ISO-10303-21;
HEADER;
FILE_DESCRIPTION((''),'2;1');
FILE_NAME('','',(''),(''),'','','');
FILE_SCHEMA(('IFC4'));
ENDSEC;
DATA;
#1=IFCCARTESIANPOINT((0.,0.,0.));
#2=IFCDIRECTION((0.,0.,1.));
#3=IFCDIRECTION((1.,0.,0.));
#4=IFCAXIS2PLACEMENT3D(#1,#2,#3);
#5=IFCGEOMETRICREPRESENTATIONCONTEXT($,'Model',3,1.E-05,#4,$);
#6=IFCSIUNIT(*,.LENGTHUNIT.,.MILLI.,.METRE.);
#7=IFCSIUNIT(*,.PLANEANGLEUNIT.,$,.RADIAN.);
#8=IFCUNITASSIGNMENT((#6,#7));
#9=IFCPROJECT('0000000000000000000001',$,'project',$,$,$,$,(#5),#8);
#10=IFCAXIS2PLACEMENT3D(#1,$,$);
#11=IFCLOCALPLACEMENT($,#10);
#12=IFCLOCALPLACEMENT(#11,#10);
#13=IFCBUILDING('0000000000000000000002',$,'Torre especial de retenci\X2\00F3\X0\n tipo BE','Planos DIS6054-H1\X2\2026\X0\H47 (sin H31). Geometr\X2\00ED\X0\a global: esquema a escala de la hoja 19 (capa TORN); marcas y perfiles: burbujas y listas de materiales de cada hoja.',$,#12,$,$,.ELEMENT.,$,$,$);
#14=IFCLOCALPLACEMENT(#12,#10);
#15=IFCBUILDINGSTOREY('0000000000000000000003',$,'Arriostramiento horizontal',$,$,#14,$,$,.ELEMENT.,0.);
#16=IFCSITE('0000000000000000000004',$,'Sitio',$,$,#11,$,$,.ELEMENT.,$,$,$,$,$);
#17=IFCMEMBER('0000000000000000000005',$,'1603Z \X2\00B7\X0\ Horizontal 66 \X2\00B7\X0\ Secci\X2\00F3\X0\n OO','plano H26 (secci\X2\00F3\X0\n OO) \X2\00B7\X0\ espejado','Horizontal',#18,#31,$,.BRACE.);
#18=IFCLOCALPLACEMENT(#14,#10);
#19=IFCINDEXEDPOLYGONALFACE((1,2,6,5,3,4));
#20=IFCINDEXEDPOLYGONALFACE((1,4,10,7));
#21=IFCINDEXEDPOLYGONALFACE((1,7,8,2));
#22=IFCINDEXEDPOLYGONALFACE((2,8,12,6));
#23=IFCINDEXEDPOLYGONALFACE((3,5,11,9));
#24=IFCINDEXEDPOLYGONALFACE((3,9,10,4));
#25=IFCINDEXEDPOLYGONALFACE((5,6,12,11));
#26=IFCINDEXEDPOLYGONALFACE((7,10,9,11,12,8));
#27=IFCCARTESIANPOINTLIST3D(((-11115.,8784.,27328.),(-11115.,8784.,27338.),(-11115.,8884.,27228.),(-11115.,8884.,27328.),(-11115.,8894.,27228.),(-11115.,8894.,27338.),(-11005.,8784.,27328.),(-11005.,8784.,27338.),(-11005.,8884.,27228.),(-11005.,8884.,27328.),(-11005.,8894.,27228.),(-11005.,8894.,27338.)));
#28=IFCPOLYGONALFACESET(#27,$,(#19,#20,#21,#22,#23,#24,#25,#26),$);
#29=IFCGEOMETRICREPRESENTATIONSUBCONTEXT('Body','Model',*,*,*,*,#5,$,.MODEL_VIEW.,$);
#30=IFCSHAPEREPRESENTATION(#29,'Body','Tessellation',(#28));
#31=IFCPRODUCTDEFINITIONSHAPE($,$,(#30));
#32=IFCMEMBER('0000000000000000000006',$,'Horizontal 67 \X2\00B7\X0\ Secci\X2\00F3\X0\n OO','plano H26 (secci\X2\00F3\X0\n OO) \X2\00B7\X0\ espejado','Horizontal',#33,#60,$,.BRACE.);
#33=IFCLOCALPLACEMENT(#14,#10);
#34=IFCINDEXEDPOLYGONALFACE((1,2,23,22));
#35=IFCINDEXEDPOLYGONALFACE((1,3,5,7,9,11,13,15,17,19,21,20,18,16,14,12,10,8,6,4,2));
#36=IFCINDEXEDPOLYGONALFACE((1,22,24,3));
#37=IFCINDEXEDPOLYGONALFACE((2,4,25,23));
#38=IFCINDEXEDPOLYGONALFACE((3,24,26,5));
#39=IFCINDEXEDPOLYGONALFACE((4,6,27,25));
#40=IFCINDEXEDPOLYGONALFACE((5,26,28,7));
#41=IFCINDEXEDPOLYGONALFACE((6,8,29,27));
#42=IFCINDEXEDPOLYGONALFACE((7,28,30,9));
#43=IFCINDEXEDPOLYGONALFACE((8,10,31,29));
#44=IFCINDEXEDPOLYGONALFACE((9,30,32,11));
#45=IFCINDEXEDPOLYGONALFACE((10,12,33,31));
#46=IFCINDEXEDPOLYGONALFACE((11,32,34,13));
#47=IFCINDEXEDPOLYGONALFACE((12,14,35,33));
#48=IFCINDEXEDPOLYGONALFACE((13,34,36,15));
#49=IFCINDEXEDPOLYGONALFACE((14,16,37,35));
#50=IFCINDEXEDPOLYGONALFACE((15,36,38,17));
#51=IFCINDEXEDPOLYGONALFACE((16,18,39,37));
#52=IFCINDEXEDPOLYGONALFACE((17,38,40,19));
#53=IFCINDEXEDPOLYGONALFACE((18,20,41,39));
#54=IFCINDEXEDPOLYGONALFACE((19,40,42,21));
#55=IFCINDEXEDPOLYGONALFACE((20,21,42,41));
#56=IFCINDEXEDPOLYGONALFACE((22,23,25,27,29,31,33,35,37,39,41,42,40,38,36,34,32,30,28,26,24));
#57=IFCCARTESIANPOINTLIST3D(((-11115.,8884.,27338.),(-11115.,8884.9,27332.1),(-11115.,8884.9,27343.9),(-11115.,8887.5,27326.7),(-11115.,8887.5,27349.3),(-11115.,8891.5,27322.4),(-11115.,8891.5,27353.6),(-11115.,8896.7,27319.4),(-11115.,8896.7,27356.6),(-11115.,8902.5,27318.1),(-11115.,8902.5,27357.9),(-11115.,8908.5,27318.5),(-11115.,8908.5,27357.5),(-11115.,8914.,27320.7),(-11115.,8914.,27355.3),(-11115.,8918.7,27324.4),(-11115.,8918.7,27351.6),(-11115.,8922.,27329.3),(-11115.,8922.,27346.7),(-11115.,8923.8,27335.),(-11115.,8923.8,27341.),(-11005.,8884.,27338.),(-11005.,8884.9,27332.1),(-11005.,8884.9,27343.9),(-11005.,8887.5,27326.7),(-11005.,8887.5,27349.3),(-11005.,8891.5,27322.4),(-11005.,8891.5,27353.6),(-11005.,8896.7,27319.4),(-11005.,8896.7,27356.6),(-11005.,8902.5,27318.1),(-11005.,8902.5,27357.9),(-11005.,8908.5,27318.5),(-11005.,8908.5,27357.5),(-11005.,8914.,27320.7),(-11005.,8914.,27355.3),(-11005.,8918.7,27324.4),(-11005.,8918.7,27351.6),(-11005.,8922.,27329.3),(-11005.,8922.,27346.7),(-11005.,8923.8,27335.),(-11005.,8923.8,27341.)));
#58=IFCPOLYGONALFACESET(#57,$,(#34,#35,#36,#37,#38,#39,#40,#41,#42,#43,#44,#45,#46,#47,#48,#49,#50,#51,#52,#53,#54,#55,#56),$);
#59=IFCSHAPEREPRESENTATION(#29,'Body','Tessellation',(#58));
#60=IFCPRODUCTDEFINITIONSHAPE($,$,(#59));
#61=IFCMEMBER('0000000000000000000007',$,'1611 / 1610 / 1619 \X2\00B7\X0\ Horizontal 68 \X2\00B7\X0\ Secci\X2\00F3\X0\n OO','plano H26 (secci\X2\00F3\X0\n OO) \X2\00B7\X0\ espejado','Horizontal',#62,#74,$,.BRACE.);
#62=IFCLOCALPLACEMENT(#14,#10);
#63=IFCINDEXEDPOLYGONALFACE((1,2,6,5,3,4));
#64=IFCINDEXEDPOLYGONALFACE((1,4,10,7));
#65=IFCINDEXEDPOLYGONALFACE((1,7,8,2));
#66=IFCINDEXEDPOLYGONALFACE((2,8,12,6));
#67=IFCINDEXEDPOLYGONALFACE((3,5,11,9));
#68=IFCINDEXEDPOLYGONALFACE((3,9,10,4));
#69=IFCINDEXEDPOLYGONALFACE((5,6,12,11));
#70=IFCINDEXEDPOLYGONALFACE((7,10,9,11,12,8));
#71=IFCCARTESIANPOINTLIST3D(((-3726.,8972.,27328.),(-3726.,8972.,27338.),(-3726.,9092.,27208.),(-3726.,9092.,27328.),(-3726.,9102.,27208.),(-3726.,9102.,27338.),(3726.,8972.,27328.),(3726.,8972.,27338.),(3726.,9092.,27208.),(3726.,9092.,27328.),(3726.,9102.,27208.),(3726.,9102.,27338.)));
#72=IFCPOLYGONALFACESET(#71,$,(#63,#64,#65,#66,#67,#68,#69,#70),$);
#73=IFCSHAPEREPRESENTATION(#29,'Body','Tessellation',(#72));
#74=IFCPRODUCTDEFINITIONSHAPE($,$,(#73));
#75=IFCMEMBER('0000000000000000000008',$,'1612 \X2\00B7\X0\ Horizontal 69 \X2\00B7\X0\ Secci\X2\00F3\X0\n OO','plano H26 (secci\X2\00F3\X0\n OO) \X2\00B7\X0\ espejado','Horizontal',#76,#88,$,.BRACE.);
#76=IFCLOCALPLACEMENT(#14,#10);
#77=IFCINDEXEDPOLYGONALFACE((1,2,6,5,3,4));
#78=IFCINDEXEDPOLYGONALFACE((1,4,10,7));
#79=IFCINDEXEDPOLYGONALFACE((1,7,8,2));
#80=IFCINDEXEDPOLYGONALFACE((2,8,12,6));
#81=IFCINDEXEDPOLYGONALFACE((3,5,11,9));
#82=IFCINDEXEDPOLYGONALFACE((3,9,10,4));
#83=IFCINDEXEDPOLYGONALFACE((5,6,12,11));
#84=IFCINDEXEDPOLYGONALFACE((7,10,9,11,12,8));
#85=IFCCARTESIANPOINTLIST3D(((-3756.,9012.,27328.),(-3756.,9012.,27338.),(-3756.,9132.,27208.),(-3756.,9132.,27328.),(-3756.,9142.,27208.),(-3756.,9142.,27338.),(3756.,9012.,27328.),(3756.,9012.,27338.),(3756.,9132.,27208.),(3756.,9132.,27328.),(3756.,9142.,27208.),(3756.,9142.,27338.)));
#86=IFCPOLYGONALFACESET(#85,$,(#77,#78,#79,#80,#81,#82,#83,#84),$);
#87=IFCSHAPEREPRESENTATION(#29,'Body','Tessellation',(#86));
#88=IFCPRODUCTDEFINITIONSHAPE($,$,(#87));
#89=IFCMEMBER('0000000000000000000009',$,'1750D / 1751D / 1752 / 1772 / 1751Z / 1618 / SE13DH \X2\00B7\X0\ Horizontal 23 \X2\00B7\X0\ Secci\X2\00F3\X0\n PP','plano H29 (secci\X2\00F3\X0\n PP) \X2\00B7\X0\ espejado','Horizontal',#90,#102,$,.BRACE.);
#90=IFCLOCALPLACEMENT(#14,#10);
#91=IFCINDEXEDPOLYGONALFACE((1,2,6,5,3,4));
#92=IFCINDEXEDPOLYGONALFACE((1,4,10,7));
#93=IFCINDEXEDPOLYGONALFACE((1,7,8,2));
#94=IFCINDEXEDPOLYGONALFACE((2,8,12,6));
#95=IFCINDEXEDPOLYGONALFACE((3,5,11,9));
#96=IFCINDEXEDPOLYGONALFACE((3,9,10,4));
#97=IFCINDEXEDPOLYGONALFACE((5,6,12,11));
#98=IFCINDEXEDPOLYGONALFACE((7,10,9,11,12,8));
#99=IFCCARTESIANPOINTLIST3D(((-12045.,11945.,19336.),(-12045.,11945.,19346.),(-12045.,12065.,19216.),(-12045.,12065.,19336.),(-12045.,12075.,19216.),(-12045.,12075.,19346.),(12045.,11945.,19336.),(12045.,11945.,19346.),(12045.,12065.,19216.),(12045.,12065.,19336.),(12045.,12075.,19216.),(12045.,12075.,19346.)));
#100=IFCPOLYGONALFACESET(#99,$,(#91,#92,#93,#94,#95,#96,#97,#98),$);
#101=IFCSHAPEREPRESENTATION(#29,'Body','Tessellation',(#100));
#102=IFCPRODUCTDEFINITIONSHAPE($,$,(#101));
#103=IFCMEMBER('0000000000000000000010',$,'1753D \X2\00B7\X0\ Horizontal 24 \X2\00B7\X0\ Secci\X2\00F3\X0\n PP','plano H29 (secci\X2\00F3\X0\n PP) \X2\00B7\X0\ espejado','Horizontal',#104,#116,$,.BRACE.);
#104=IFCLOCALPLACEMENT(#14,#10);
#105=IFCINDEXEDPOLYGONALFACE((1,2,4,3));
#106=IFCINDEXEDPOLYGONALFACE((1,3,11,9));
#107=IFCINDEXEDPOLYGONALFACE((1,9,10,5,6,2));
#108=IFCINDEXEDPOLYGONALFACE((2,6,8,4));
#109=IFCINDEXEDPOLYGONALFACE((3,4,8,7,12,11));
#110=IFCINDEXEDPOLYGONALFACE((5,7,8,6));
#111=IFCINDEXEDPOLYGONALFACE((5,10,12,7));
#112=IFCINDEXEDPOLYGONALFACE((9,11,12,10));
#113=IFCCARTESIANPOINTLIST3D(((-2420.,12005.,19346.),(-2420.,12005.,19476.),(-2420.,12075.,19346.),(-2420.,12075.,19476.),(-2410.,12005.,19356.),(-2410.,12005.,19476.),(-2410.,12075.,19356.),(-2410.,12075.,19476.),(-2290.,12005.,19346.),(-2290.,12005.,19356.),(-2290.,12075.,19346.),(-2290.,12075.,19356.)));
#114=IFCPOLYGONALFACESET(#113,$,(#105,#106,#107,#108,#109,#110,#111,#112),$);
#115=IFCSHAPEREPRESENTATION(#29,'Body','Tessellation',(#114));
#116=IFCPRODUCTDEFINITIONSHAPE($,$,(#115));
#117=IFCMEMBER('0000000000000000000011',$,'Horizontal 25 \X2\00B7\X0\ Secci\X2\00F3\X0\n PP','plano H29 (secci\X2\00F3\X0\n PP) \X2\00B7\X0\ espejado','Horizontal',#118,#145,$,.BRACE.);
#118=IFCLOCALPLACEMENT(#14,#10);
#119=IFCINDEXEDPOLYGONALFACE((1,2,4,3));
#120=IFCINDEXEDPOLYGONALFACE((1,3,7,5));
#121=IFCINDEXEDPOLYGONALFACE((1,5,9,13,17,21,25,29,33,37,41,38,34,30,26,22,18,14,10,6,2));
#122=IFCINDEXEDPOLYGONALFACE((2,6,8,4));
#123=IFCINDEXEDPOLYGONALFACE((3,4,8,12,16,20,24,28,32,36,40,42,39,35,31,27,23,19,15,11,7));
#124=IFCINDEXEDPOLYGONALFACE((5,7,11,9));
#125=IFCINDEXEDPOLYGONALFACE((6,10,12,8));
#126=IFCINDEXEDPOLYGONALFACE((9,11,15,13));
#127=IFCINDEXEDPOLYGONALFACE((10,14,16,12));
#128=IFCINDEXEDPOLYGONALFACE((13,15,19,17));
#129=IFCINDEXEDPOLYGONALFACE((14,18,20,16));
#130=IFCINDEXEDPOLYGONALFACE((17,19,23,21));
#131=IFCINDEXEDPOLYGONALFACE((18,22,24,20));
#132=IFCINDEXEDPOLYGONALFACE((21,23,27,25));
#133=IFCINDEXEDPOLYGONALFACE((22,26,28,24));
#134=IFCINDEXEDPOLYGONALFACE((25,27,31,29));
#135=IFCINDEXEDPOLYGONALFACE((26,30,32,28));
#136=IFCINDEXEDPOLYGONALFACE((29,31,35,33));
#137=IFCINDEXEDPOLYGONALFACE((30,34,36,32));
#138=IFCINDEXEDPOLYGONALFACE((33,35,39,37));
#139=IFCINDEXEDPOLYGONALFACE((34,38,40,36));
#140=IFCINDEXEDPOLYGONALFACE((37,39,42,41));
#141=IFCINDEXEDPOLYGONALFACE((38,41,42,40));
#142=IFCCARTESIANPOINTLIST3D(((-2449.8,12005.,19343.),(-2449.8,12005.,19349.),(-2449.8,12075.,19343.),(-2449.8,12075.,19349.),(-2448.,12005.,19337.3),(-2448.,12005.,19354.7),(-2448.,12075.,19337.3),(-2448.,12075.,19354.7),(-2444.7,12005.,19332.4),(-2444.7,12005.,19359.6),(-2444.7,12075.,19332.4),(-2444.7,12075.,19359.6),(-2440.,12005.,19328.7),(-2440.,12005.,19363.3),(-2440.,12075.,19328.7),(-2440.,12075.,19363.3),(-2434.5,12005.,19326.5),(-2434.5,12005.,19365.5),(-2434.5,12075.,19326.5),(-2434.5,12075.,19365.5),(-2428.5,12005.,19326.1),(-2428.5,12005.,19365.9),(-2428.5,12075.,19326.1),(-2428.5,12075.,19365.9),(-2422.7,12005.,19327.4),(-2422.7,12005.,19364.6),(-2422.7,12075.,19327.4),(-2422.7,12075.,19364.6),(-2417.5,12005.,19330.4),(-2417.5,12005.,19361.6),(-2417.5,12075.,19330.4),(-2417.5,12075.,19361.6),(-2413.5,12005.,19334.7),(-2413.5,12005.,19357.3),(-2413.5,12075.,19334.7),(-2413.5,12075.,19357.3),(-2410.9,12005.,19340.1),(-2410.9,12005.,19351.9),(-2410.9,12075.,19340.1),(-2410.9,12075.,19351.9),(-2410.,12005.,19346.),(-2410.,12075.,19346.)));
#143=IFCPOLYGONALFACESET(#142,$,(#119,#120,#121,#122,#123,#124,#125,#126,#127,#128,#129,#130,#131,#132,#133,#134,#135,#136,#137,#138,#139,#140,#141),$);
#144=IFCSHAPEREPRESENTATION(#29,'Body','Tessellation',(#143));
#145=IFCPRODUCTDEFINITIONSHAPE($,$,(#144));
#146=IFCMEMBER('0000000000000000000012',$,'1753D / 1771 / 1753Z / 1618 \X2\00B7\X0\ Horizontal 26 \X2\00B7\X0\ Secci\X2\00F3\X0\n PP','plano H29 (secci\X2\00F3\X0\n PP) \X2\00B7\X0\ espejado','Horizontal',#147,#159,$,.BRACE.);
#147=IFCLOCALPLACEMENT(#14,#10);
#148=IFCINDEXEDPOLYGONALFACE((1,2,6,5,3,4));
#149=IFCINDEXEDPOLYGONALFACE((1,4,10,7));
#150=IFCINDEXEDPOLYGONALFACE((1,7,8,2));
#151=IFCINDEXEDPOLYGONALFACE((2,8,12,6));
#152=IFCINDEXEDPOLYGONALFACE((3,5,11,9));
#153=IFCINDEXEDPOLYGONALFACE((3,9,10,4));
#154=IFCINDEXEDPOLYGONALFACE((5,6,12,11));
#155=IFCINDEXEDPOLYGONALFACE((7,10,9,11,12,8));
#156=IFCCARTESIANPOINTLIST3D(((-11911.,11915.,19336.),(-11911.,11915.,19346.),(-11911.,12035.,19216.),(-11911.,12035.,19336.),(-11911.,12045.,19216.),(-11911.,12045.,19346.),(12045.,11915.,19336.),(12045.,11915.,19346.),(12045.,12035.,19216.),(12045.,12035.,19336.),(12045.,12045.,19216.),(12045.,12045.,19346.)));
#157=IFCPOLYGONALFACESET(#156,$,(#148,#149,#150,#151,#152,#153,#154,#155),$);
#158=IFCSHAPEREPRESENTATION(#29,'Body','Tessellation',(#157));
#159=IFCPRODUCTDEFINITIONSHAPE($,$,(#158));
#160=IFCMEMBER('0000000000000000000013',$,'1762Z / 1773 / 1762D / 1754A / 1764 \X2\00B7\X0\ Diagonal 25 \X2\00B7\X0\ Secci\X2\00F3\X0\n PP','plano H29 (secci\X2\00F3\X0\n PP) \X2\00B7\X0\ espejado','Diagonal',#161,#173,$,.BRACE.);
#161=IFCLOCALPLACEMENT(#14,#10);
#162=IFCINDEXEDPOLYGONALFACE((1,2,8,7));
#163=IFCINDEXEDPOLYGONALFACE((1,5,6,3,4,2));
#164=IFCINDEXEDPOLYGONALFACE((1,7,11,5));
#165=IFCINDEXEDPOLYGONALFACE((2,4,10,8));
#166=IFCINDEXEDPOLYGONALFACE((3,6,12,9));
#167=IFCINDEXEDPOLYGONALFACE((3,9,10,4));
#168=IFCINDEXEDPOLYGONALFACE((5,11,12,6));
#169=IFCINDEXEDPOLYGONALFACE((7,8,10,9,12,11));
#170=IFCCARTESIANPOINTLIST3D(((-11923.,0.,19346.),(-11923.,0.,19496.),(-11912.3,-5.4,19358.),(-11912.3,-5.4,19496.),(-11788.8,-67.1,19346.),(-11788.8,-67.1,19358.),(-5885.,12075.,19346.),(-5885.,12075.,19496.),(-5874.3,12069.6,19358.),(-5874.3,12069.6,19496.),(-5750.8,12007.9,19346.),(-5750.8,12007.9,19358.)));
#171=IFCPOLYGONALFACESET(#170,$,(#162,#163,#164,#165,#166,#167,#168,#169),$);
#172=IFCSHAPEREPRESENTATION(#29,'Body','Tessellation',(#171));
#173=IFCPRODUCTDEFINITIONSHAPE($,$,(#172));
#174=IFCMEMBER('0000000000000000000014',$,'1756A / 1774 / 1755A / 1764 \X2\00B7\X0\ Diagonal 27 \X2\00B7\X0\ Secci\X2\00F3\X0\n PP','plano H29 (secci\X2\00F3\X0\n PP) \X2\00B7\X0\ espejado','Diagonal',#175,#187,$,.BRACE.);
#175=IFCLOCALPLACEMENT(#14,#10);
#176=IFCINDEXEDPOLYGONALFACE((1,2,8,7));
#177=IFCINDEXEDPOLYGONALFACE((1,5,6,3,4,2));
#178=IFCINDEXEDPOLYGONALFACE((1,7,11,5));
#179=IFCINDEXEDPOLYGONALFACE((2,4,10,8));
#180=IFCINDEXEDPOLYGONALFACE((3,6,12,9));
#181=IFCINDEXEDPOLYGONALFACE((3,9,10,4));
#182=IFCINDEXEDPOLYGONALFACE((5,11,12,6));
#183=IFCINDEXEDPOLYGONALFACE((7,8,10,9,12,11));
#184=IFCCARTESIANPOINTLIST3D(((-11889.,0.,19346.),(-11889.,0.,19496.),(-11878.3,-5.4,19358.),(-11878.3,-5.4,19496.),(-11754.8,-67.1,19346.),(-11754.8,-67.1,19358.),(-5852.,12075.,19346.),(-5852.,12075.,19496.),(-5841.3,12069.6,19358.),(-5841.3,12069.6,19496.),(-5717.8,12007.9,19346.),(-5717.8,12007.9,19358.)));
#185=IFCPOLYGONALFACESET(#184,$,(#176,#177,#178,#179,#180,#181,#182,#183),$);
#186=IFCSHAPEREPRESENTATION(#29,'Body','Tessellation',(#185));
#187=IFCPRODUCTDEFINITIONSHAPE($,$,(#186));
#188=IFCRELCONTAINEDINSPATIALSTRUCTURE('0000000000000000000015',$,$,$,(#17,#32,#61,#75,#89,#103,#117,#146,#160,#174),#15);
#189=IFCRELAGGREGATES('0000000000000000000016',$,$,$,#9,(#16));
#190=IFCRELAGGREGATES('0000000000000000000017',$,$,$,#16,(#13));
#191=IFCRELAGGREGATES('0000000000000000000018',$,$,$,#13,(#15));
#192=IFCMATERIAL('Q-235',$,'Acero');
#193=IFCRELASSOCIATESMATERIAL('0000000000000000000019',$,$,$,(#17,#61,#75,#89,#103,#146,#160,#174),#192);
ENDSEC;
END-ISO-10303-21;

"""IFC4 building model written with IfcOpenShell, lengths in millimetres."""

from ifc_helpers import new_model, si_unit, frame, frame_2d, origin, origin_with_axes, place, context, subcontext, project, spatial, circle, l_section, extrude, material, element, save


model = new_model("IFC4")

# Units and contexts
model_context = context("Model", 3, precision=1e-05, world=origin_with_axes())
body_context = subcontext(model_context, "Body", "Model", "MODEL_VIEW")
ifc_project = project(units=[si_unit("LENGTHUNIT", "METRE", prefix="MILLI"), si_unit("PLANEANGLEUNIT", "RADIAN")], contexts=[model_context])

# Site, building, storey
site_placement = place(None, origin())
site = spatial("IfcSite", under=ifc_project, at=site_placement, Name="Sitio", CompositionType="ELEMENT")
building_placement = place(site_placement, origin())
building = spatial("IfcBuilding", under=site, at=building_placement, Name="Torre especial de retención tipo BE", Description="Planos DIS6054-H1…H47 (sin H31). Geometría global: esquema a escala de la hoja 19 (capa TORN); marcas y perfiles: burbujas y listas de materiales de cada hoja.", CompositionType="ELEMENT")
storey_placement = place(building_placement, origin())
storey = spatial("IfcBuildingStorey", under=building, at=storey_placement, Name="Arriostramiento horizontal", CompositionType="ELEMENT", Elevation=0.0)

# Members
ifc_material = material(Name="Q-235", Category="Acero")
member_1_placement = place(storey_placement, frame((-11115.0, 8894.0, 27338.0), z_axis=(1.0, 0.0, 0.0), x_axis=(0.0, -1.0, 0.0)))
element("IfcMember", 1, at=member_1_placement, inside=storey, material=ifc_material, Name="1603Z · Horizontal 66 · Sección OO", Description="plano H26 (sección OO) · espejado", ObjectType="Horizontal", PredefinedType="BRACE", context=body_context, shape_type="SweptSolid", body=[
    extrude(l_section(Depth=110.0, Width=110.0, Thickness=10.0, at=frame_2d((55.0, 55.0))), None, (0.0, 0.0, 1.0), 110.0),
])
member_2_placement = place(storey_placement, frame((-11115.0, 8904.0, 27338.0), z_axis=(1.0, 0.0, 0.0), x_axis=(0.0, -1.0, 0.0)))
element("IfcMember", 2, at=member_2_placement, inside=storey, Name="Horizontal 67 · Sección OO", Description="plano H26 (sección OO) · espejado", ObjectType="Horizontal", PredefinedType="BRACE", context=body_context, shape_type="SweptSolid", body=[
    extrude(circle(Radius=20.0), None, (0.0, 0.0, 1.0), 110.0),
])
member_3_placement = place(storey_placement, frame((-3726.0, 9102.0, 27338.0), z_axis=(1.0, 0.0, 0.0), x_axis=(0.0, -1.0, 0.0)))
element("IfcMember", 3, at=member_3_placement, inside=storey, material=ifc_material, Name="1611 / 1610 / 1619 · Horizontal 68 · Sección OO", Description="plano H26 (sección OO) · espejado", ObjectType="Horizontal", PredefinedType="BRACE", context=body_context, shape_type="SweptSolid", body=[
    extrude(l_section(Depth=130.0, Width=130.0, Thickness=10.0, at=frame_2d((65.0, 65.0))), None, (0.0, 0.0, 1.0), 7452.0),
])
member_4_placement = place(storey_placement, frame((-3756.0, 9142.0, 27338.0), z_axis=(1.0, 0.0, 0.0), x_axis=(0.0, -1.0, 0.0)))
element("IfcMember", 4, at=member_4_placement, inside=storey, material=ifc_material, Name="1612 · Horizontal 69 · Sección OO", Description="plano H26 (sección OO) · espejado", ObjectType="Horizontal", PredefinedType="BRACE", context=body_context, shape_type="SweptSolid", body=[
    extrude(l_section(Depth=130.0, Width=130.0, Thickness=10.0, at=frame_2d((65.0, 65.0))), None, (0.0, 0.0, 1.0), 7512.0),
])
member_5_placement = place(storey_placement, frame((-12045.0, 12075.0, 19346.0), z_axis=(1.0, 0.0, 0.0), x_axis=(0.0, -1.0, 0.0)))
element("IfcMember", 5, at=member_5_placement, inside=storey, material=ifc_material, Name="1750D / 1751D / 1752 / 1772 / 1751Z / 1618 / SE13DH · Horizontal 23 · Sección PP", Description="plano H29 (sección PP) · espejado", ObjectType="Horizontal", PredefinedType="BRACE", context=body_context, shape_type="SweptSolid", body=[
    extrude(l_section(Depth=130.0, Width=130.0, Thickness=10.0, at=frame_2d((65.0, 65.0))), None, (0.0, 0.0, 1.0), 24090.0),
])
member_6_placement = place(storey_placement, frame((-2420.0, 12075.0, 19346.0), z_axis=(0.0, -1.0, 0.0), x_axis=(1.0, 0.0, 0.0)))
element("IfcMember", 6, at=member_6_placement, inside=storey, material=ifc_material, Name="1753D · Horizontal 24 · Sección PP", Description="plano H29 (sección PP) · espejado", ObjectType="Horizontal", PredefinedType="BRACE", context=body_context, shape_type="SweptSolid", body=[
    extrude(l_section(Depth=130.0, Width=130.0, Thickness=10.0, at=frame_2d((65.0, 65.0))), None, (0.0, 0.0, 1.0), 70.0),
])
member_7_placement = place(storey_placement, frame((-2430.0, 12075.0, 19346.0), z_axis=(0.0, -1.0, 0.0), x_axis=(1.0, 0.0, 0.0)))
element("IfcMember", 7, at=member_7_placement, inside=storey, Name="Horizontal 25 · Sección PP", Description="plano H29 (sección PP) · espejado", ObjectType="Horizontal", PredefinedType="BRACE", context=body_context, shape_type="SweptSolid", body=[
    extrude(circle(Radius=20.0), None, (0.0, 0.0, 1.0), 70.0),
])
member_8_placement = place(storey_placement, frame((-11911.0, 12045.0, 19346.0), z_axis=(1.0, 0.0, 0.0), x_axis=(0.0, -1.0, 0.0)))
element("IfcMember", 8, at=member_8_placement, inside=storey, material=ifc_material, Name="1753D / 1771 / 1753Z / 1618 · Horizontal 26 · Sección PP", Description="plano H29 (sección PP) · espejado", ObjectType="Horizontal", PredefinedType="BRACE", context=body_context, shape_type="SweptSolid", body=[
    extrude(l_section(Depth=130.0, Width=130.0, Thickness=10.0, at=frame_2d((65.0, 65.0))), None, (0.0, 0.0, 1.0), 23956.0),
])
member_9_placement = place(storey_placement, frame((-5885.0, 12075.0, 19346.0), z_axis=(-0.447243, -0.894412, 0.0), x_axis=(0.894412, -0.447243, 0.0)))
element("IfcMember", 9, at=member_9_placement, inside=storey, material=ifc_material, Name="1762Z / 1773 / 1762D / 1754A / 1764 · Diagonal 25 · Sección PP", Description="plano H29 (sección PP) · espejado", ObjectType="Diagonal", PredefinedType="BRACE", context=body_context, shape_type="SweptSolid", body=[
    extrude(l_section(Depth=150.0, Width=150.0, Thickness=12.0, at=frame_2d((75.0, 75.0))), None, (0.0, 0.0, 1.0), 13500.5),
])
member_10_placement = place(storey_placement, frame((-5852.0, 12075.0, 19346.0), z_axis=(-0.447184, -0.894442, 0.0), x_axis=(0.894442, -0.447184, 0.0)))
element("IfcMember", 10, at=member_10_placement, inside=storey, material=ifc_material, Name="1756A / 1774 / 1755A / 1764 · Diagonal 27 · Sección PP", Description="plano H29 (sección PP) · espejado", ObjectType="Diagonal", PredefinedType="BRACE", context=body_context, shape_type="SweptSolid", body=[
    extrude(l_section(Depth=150.0, Width=150.0, Thickness=12.0, at=frame_2d((75.0, 75.0))), None, (0.0, 0.0, 1.0), 13500.0),
])

save(model, "model.ifc")
